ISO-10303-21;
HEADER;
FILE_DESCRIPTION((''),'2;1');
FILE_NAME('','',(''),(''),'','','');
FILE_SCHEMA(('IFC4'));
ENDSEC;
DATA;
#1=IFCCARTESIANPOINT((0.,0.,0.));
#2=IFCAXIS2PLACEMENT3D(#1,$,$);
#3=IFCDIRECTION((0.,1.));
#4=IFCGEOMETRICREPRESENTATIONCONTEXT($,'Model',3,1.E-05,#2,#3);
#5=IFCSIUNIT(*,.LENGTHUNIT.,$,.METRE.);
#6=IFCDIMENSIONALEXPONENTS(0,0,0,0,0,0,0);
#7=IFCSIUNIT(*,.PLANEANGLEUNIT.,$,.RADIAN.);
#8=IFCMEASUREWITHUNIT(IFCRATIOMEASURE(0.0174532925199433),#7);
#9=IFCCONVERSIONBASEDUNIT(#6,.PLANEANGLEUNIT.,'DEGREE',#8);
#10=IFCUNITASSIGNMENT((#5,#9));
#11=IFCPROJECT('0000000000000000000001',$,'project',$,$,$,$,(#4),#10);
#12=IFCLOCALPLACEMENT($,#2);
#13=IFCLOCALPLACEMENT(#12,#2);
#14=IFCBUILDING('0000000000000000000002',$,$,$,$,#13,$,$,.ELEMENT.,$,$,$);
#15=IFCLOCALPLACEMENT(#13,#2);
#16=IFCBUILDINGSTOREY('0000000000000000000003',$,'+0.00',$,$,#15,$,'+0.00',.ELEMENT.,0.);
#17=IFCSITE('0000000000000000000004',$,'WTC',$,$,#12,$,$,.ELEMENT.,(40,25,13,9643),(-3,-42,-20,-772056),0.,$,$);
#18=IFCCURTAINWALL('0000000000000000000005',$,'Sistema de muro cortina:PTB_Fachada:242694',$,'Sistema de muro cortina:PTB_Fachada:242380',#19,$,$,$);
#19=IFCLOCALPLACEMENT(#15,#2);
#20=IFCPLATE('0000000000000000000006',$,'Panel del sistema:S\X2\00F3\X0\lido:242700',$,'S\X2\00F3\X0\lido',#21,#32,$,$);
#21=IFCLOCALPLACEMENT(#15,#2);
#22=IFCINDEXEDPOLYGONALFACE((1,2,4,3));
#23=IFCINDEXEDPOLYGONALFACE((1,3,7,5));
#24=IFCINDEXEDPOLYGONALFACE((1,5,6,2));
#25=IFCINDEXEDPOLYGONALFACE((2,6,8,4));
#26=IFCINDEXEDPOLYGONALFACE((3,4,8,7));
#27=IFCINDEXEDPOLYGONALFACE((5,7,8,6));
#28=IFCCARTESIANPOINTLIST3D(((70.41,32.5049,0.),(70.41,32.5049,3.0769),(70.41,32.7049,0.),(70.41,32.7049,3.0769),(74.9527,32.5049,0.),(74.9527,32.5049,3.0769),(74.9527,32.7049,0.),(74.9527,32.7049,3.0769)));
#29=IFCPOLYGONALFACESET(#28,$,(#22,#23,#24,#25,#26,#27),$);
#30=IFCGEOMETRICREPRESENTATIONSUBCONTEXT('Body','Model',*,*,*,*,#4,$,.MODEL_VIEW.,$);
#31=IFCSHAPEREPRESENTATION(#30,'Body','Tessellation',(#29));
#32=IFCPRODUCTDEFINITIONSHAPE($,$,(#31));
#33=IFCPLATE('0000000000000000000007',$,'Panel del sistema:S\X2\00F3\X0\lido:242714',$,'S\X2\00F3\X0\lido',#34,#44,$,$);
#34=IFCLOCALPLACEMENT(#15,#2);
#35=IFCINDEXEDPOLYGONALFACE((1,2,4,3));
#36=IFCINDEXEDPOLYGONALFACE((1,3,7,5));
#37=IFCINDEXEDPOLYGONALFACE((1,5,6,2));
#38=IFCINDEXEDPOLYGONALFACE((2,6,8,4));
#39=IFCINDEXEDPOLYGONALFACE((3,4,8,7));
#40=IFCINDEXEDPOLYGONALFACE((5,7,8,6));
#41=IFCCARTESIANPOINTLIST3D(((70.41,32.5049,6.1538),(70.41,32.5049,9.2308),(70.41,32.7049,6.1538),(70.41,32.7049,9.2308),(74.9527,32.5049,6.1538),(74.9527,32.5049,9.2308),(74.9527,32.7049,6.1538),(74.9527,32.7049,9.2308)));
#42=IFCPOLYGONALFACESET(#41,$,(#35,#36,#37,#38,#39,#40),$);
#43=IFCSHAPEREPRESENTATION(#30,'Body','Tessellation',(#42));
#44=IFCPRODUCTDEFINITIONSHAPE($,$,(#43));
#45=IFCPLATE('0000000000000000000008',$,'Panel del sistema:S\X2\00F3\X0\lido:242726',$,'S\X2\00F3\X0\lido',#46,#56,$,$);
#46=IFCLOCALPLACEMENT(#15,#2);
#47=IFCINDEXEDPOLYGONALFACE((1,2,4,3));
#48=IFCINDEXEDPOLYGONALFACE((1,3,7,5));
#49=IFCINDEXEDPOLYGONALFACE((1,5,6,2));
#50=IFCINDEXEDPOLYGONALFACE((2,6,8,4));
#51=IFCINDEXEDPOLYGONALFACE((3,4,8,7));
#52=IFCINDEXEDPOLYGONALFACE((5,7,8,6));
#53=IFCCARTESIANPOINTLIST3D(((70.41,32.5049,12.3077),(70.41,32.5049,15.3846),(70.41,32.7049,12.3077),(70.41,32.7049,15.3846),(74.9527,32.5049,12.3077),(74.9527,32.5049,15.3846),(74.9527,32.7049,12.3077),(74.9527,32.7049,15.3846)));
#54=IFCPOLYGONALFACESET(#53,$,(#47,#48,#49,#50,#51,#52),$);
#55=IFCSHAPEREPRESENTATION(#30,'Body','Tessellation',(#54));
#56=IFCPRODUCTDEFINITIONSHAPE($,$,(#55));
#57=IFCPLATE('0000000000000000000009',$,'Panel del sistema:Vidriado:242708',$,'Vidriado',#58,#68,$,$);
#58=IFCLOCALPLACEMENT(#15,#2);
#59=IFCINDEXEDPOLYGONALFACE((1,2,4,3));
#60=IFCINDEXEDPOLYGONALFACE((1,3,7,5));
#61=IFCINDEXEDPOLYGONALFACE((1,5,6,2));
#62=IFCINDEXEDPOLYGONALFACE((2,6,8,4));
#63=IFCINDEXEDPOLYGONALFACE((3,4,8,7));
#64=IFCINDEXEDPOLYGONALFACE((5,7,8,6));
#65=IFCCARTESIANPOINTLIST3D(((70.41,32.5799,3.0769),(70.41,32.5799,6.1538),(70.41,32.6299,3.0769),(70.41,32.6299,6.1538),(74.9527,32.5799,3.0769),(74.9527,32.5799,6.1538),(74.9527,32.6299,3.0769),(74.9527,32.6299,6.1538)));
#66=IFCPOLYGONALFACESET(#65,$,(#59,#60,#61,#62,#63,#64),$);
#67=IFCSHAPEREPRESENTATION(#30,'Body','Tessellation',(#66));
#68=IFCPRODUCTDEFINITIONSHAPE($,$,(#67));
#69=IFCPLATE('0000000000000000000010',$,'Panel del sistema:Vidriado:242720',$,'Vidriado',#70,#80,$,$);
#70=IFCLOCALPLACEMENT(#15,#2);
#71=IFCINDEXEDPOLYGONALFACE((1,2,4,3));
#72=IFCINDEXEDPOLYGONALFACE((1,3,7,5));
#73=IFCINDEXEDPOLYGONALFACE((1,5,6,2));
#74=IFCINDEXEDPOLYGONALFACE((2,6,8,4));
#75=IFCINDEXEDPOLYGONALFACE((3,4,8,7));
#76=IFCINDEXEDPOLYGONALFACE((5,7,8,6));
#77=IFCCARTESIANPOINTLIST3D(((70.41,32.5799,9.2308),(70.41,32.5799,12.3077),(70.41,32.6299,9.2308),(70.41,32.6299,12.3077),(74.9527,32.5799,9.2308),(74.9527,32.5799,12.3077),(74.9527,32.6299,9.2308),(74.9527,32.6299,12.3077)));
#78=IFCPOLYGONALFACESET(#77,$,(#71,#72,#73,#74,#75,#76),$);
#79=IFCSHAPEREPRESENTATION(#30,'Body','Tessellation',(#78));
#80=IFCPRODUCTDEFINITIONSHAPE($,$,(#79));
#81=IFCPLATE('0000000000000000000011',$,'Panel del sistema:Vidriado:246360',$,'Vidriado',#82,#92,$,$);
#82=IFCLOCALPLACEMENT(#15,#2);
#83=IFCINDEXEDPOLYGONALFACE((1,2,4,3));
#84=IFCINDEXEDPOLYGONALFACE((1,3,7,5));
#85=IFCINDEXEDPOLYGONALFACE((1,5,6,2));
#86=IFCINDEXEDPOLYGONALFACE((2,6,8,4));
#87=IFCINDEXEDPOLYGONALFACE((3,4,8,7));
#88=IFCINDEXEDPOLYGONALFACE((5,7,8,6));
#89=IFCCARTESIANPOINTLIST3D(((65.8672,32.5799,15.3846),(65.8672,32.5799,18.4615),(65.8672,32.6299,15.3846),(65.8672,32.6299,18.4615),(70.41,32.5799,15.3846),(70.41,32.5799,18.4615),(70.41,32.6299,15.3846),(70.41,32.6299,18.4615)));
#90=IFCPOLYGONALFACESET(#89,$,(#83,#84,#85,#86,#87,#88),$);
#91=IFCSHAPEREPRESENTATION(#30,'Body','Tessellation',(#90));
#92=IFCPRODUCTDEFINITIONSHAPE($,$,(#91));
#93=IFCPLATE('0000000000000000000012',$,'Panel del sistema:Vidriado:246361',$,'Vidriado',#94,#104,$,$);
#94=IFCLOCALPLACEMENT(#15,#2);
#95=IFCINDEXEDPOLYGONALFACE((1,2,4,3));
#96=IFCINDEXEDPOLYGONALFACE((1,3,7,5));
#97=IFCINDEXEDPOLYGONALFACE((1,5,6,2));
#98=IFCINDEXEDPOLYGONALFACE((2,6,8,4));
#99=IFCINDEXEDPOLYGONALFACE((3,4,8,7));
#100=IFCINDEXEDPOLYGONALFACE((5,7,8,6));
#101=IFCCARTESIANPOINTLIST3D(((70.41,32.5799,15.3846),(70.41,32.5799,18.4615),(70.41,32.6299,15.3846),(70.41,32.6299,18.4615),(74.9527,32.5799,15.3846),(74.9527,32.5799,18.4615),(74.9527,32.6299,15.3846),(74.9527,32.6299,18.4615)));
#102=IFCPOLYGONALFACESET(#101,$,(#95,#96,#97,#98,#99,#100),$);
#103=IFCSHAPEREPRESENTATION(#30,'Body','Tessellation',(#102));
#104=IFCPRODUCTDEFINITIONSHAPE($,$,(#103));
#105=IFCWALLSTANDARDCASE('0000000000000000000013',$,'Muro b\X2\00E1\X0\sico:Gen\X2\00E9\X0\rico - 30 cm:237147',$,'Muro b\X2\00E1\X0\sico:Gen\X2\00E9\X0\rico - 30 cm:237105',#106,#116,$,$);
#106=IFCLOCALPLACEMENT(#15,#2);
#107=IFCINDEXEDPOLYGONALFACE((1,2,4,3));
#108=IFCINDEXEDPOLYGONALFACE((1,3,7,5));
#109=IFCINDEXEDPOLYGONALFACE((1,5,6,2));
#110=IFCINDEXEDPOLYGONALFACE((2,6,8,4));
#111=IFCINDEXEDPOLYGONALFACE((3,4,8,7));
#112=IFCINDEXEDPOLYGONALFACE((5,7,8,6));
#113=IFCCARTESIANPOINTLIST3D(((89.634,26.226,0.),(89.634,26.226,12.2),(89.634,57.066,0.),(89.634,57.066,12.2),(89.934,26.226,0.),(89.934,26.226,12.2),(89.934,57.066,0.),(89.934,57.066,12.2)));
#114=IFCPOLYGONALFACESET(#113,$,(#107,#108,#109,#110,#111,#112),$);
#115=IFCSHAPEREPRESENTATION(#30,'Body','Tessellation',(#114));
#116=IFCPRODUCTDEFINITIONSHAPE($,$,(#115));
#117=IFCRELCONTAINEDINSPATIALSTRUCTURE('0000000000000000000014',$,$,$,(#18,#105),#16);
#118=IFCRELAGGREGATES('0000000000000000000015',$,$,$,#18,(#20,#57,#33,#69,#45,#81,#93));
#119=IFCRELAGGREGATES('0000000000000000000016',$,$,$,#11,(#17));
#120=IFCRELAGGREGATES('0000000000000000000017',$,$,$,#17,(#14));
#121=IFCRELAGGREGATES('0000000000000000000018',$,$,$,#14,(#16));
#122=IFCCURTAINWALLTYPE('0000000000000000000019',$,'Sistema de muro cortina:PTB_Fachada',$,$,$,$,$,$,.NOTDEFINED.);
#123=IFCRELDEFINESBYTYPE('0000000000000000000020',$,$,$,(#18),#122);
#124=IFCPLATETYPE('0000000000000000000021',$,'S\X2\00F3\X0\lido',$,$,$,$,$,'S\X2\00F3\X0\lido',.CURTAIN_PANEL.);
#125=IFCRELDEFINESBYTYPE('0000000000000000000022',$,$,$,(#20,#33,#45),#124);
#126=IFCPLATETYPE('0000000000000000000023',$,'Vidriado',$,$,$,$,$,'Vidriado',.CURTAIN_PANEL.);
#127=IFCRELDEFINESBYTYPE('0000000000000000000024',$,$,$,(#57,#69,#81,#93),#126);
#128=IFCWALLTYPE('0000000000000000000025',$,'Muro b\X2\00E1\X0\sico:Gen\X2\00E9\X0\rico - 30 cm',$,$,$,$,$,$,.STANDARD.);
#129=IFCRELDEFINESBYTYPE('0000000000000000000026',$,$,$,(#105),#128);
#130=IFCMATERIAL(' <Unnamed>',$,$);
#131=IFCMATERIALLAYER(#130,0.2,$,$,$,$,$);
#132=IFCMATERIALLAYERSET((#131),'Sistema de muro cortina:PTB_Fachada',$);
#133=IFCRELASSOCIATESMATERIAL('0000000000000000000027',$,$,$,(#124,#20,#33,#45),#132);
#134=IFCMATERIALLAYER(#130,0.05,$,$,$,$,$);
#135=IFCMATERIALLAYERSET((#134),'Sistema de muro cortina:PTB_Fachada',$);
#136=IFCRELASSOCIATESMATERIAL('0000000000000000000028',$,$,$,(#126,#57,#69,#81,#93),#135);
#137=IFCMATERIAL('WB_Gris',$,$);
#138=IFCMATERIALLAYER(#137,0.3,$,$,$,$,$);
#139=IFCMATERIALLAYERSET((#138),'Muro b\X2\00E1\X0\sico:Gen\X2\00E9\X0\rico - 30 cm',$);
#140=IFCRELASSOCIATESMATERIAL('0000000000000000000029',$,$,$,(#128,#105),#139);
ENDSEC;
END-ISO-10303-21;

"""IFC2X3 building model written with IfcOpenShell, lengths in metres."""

from ifc_helpers import new_model, entity, si_unit, converted_unit, direction, frame, frame_2d, origin, origin_2d_with_axis, place, context, subcontext, project, spatial, polyline, rectangle, extrude, clip, bounded_halfspace, source, transform, mapped, material, layer, layer_set, layer_usage, type_object, type_shapes, element, aggregate, save


model = new_model("IFC2X3")

# Units and contexts
model_context = context("Model", 3, precision=1e-05, world=origin(), true_north=direction((0.0, 1.0)))
body_context = subcontext(model_context, "Body", "Model", "MODEL_VIEW")
ifc_project = project(units=[si_unit("LENGTHUNIT", "METRE"), converted_unit("PLANEANGLEUNIT", "DEGREE", entity("IfcRatioMeasure", 0.0174532925199433), si_unit("PLANEANGLEUNIT", "RADIAN"), dimensions=[0, 0, 0, 0, 0, 0, 0])], contexts=[model_context])

# Site, building, storey
site_placement = place(None, origin())
site = spatial("IfcSite", under=ifc_project, at=site_placement, Name="WTC", CompositionType="ELEMENT", RefLatitude=(40, 25, 13, 9643), RefLongitude=(-3, -42, -20, -772056), RefElevation=0.0)
building_placement = place(site_placement, origin())
building = spatial("IfcBuilding", under=site, at=building_placement, CompositionType="ELEMENT")
storey_placement = place(building_placement, origin())
storey = spatial("IfcBuildingStorey", under=building, at=storey_placement, Name="+0.00", LongName="+0.00", CompositionType="ELEMENT", Elevation=0.0)

# Curtain wall, plates
curtain_wall_type = type_object("IfcCurtainWallType", Name="Sistema de muro cortina:PTB_Fachada", PredefinedType="NOTDEFINED")
ifc_material_1 = material(Name=" <Unnamed>")
ifc_layer_1 = layer(ifc_material_1, 0.2)
ifc_layer_set_1 = layer_set([ifc_layer_1], Name="Sistema de muro cortina:PTB_Fachada")
ifc_layer_2 = layer(ifc_material_1, 0.05)
ifc_layer_set_2 = layer_set([ifc_layer_2], Name="Sistema de muro cortina:PTB_Fachada")
curtain_wall_1_placement = place(storey_placement, origin())
curtain_wall_1 = element("IfcCurtainWall", 1, at=curtain_wall_1_placement, inside=storey, type_object=curtain_wall_type, Name="Sistema de muro cortina:PTB_Fachada:242694", ObjectType="Sistema de muro cortina:PTB_Fachada:242380")
ifc_layer_usage_1 = layer_usage(ifc_layer_set_1, "AXIS3", "POSITIVE", 0.0)
plate_type_1 = type_object("IfcPlateType", Name="Sólido", ElementType="Sólido", PredefinedType="CURTAIN_PANEL", material=ifc_layer_set_1)
shared_shape_1 = source(origin(), body_context, "Body", "SweptSolid", [
    extrude(rectangle(XDim=0.2, YDim=4.5427, at=origin_2d_with_axis()), frame((0.0, 0.0, 0.0), z_axis=(0.0, 0.0, 1.0), x_axis=(0.0, 1.0, 0.0)), (0.0, 0.0, 1.0), 3.0769),
])
type_shapes(plate_type_1, [shared_shape_1])
plate_1_placement = place(curtain_wall_1_placement, frame((72.6813, 32.6049, 0.0)))
plate_1 = element("IfcPlate", 2, at=plate_1_placement, type_object=plate_type_1, material=ifc_layer_usage_1, Name="Panel del sistema:Sólido:242700", ObjectType="Sólido", context=body_context, shape_type="MappedRepresentation", body=[
    mapped(shared_shape_1, transform((0.0, 0.0, 0.0), scale=1.0)),
])
ifc_layer_usage_2 = layer_usage(ifc_layer_set_1, "AXIS3", "POSITIVE", 0.0)
plate_2_placement = place(curtain_wall_1_placement, frame((72.6813, 32.6049, 6.1538)))
plate_2 = element("IfcPlate", 3, at=plate_2_placement, type_object=plate_type_1, material=ifc_layer_usage_2, Name="Panel del sistema:Sólido:242714", ObjectType="Sólido", context=body_context, shape_type="MappedRepresentation", body=[
    mapped(shared_shape_1, transform((0.0, 0.0, 0.0), scale=1.0)),
])
ifc_layer_usage_3 = layer_usage(ifc_layer_set_1, "AXIS3", "POSITIVE", 0.0)
plate_3_placement = place(curtain_wall_1_placement, frame((72.6813, 32.6049, 12.3077)))
plate_3 = element("IfcPlate", 4, at=plate_3_placement, type_object=plate_type_1, material=ifc_layer_usage_3, Name="Panel del sistema:Sólido:242726", ObjectType="Sólido", context=body_context, shape_type="MappedRepresentation", body=[
    mapped(shared_shape_1, transform((0.0, 0.0, 0.0), scale=1.0)),
])
ifc_layer_usage_4 = layer_usage(ifc_layer_set_2, "AXIS3", "POSITIVE", 0.0)
plate_type_2 = type_object("IfcPlateType", Name="Vidriado", ElementType="Vidriado", PredefinedType="CURTAIN_PANEL", material=ifc_layer_set_2)
shared_shape_2 = source(origin(), body_context, "Body", "SweptSolid", [
    extrude(rectangle(XDim=0.05, YDim=4.5427, at=origin_2d_with_axis()), frame((0.0, 0.0, 0.0), z_axis=(0.0, 0.0, 1.0), x_axis=(0.0, 1.0, 0.0)), (0.0, 0.0, 1.0), 3.0769),
])
type_shapes(plate_type_2, [shared_shape_2])
plate_4_placement = place(curtain_wall_1_placement, frame((72.6813, 32.6049, 3.0769)))
plate_4 = element("IfcPlate", 5, at=plate_4_placement, type_object=plate_type_2, material=ifc_layer_usage_4, Name="Panel del sistema:Vidriado:242708", ObjectType="Vidriado", context=body_context, shape_type="MappedRepresentation", body=[
    mapped(shared_shape_2, transform((0.0, 0.0, 0.0), scale=1.0)),
])
ifc_layer_usage_5 = layer_usage(ifc_layer_set_2, "AXIS3", "POSITIVE", 0.0)
plate_5_placement = place(curtain_wall_1_placement, frame((72.6813, 32.6049, 9.2308)))
plate_5 = element("IfcPlate", 6, at=plate_5_placement, type_object=plate_type_2, material=ifc_layer_usage_5, Name="Panel del sistema:Vidriado:242720", ObjectType="Vidriado", context=body_context, shape_type="MappedRepresentation", body=[
    mapped(shared_shape_2, transform((0.0, 0.0, 0.0), scale=1.0)),
])
ifc_layer_usage_6 = layer_usage(ifc_layer_set_2, "AXIS3", "POSITIVE", 0.0)
plate_6_placement = place(curtain_wall_1_placement, frame((68.1386, 32.6049, 15.3846)))
plate_6 = element("IfcPlate", 7, at=plate_6_placement, type_object=plate_type_2, material=ifc_layer_usage_6, Name="Panel del sistema:Vidriado:246360", ObjectType="Vidriado", context=body_context, shape_type="MappedRepresentation", body=[
    mapped(shared_shape_2, transform((0.0, 0.0, 0.0), scale=1.0)),
])
ifc_layer_usage_7 = layer_usage(ifc_layer_set_2, "AXIS3", "POSITIVE", 0.0)
plate_7_placement = place(curtain_wall_1_placement, frame((72.6813, 32.6049, 15.3846)))
plate_7 = element("IfcPlate", 8, at=plate_7_placement, type_object=plate_type_2, material=ifc_layer_usage_7, Name="Panel del sistema:Vidriado:246361", ObjectType="Vidriado", context=body_context, shape_type="MappedRepresentation", body=[
    mapped(shared_shape_2, transform((0.0, 0.0, 0.0), scale=1.0)),
])
aggregate(curtain_wall_1, [plate_1, plate_4, plate_2, plate_5, plate_3, plate_6, plate_7])

# Wall
ifc_material_2 = material(Name="WB_Gris")
ifc_layer_3 = layer(ifc_material_2, 0.3)
ifc_layer_set_3 = layer_set([ifc_layer_3], Name="Muro básico:Genérico - 30 cm")
ifc_layer_usage_8 = layer_usage(ifc_layer_set_3, "AXIS2", "POSITIVE", -0.15)
wall_type = type_object("IfcWallType", Name="Muro básico:Genérico - 30 cm", PredefinedType="STANDARD", material=ifc_layer_set_3)
wall_placement = place(storey_placement, frame((89.784, 26.226, 0.0), z_axis=(0.0, 0.0, 1.0), x_axis=(0.0, 1.0, 0.0)))
element("IfcWallStandardCase", 9, at=wall_placement, inside=storey, type_object=wall_type, material=ifc_layer_usage_8, Name="Muro básico:Genérico - 30 cm:237147", ObjectType="Muro básico:Genérico - 30 cm:237105", context=body_context, shape_type="Clipping", body=[
    clip(extrude(rectangle(XDim=30.84, YDim=0.3, at=frame_2d((15.42, 0.0), x_axis=(-1.0, 0.0))), origin(), (0.0, 0.0, 1.0), 12.2), bounded_halfspace(frame((0.0, -0.15, 12.2), z_axis=(0.0, 0.0, -1.0), x_axis=(-1.0, 0.0, 0.0)), True, frame((0.0, -0.15, 12.2), z_axis=(0.0, 0.0, -1.0), x_axis=(-1.0, 0.0, 0.0)), polyline([(0.0, 0.0), (0.0, 0.3), (-30.84, 0.3), (-30.84, 0.0), (0.0, 0.0)]))),
])

save(model, "model.ifc")
